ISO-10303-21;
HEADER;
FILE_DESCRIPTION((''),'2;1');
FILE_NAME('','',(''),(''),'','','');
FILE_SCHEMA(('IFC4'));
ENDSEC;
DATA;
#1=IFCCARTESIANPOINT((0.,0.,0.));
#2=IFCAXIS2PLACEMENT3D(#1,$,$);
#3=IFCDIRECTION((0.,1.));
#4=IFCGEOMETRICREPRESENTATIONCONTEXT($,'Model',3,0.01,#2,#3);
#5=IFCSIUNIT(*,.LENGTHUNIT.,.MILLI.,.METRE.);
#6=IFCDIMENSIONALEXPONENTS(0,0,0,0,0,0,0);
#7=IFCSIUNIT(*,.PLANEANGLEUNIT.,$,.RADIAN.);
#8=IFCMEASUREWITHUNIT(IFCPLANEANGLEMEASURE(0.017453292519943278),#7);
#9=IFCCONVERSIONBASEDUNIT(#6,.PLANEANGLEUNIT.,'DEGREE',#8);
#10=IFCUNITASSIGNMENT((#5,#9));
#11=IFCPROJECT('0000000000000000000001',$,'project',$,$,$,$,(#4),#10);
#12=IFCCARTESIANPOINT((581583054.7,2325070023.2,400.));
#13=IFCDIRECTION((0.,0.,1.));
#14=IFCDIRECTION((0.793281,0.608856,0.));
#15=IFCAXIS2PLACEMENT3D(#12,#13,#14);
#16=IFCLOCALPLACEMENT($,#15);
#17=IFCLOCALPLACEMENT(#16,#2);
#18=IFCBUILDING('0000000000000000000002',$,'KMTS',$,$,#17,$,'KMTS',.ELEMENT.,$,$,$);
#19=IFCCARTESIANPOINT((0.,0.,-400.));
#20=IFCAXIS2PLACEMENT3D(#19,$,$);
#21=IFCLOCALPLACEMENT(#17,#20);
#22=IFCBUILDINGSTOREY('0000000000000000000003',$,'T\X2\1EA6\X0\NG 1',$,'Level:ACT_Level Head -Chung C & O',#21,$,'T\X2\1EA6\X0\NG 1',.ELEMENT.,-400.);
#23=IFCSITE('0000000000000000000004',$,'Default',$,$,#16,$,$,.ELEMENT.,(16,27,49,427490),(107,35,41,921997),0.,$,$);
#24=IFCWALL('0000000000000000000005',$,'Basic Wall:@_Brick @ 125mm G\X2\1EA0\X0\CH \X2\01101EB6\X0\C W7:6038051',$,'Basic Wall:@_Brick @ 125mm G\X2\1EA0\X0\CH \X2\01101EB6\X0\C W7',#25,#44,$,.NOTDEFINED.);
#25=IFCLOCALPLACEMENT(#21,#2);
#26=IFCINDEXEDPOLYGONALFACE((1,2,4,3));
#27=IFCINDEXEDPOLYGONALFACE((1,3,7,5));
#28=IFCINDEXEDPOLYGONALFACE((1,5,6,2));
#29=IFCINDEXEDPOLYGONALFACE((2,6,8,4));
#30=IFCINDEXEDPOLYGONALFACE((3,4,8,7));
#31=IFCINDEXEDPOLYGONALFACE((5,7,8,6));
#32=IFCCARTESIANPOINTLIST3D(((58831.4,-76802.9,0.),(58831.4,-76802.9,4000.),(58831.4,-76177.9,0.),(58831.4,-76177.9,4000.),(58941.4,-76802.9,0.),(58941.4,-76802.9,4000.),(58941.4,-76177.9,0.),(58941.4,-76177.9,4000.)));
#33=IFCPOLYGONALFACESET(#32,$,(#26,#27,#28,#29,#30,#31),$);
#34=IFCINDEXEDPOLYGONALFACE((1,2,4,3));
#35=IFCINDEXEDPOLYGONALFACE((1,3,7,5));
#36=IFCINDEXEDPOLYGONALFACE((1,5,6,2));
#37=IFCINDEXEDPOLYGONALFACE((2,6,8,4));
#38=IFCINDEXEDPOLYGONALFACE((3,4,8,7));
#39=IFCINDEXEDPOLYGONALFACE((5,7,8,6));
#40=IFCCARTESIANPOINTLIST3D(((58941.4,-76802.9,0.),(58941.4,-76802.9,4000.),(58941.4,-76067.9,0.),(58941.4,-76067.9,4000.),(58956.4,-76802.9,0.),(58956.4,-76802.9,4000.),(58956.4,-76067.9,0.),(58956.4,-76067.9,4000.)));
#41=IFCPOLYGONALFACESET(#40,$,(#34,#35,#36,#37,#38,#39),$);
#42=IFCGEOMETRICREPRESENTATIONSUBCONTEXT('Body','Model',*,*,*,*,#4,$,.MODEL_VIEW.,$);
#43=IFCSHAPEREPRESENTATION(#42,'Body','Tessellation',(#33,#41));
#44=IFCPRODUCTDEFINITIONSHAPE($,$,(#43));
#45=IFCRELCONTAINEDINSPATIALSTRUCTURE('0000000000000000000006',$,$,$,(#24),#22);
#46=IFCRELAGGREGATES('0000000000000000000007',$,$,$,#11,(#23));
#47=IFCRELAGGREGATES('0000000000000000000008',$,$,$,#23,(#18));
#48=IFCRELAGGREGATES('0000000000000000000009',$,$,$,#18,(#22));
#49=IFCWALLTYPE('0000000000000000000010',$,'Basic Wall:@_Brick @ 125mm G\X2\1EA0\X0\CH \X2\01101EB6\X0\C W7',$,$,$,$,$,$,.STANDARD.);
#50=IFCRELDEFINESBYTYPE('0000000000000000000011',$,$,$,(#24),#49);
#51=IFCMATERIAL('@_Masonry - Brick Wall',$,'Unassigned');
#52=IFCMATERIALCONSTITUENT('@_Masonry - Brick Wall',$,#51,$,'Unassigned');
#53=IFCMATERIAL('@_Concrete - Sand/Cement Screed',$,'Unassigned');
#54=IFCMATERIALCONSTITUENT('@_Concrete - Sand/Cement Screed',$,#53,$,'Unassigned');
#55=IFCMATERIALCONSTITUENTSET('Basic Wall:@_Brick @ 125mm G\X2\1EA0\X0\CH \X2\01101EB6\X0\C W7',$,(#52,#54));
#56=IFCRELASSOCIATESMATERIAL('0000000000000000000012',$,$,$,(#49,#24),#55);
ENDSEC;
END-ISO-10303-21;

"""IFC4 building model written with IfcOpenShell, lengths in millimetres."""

from ifc_helpers import new_model, entity, si_unit, converted_unit, direction, frame, origin, place, context, subcontext, project, spatial, indexed_curve, outline, extrude, material, constituent, constituent_set, type_object, element, save


model = new_model("IFC4")

# Units and contexts
model_context = context("Model", 3, precision=0.01, world=origin(), true_north=direction((0.0, 1.0)))
body_context = subcontext(model_context, "Body", "Model", "MODEL_VIEW")
ifc_project = project(units=[si_unit("LENGTHUNIT", "METRE", prefix="MILLI"), converted_unit("PLANEANGLEUNIT", "DEGREE", entity("IfcPlaneAngleMeasure", 0.017453292519943278), si_unit("PLANEANGLEUNIT", "RADIAN"), dimensions=[0, 0, 0, 0, 0, 0, 0])], contexts=[model_context])

# Site, building, storey
site_placement = place(None, frame((581583054.7, 2325070023.2, 400.0), z_axis=(0.0, 0.0, 1.0), x_axis=(0.793281, 0.608856, 0.0)))
site = spatial("IfcSite", under=ifc_project, at=site_placement, Name="Default", CompositionType="ELEMENT", RefLatitude=(16, 27, 49, 427490), RefLongitude=(107, 35, 41, 921997), RefElevation=0.0)
building_placement = place(site_placement, origin())
building = spatial("IfcBuilding", under=site, at=building_placement, Name="KMTS", LongName="KMTS", CompositionType="ELEMENT")
storey_placement = place(building_placement, frame((0.0, 0.0, -400.0)))
storey = spatial("IfcBuildingStorey", under=building, at=storey_placement, Name="TẦNG 1", ObjectType="Level:ACT_Level Head -Chung C & O", LongName="TẦNG 1", CompositionType="ELEMENT", Elevation=-400.0)

# Wall
ifc_material_1 = material(Name="@_Masonry - Brick Wall", Category="Unassigned")
ifc_constituent_1 = constituent(ifc_material_1, Name="@_Masonry - Brick Wall", Category="Unassigned")
ifc_material_2 = material(Name="@_Concrete - Sand/Cement Screed", Category="Unassigned")
ifc_constituent_2 = constituent(ifc_material_2, Name="@_Concrete - Sand/Cement Screed", Category="Unassigned")
ifc_constituent_set_1 = constituent_set(constituents=[ifc_constituent_1, ifc_constituent_2], Name="Basic Wall:@_Brick @ 125mm GẠCH ĐẶC W7")
wall_type_1 = type_object("IfcWallType", Name="Basic Wall:@_Brick @ 125mm GẠCH ĐẶC W7", PredefinedType="STANDARD", material=ifc_constituent_set_1)
wall_1_placement = place(storey_placement, frame((58893.9, -76177.9, 0.0), z_axis=(0.0, 0.0, 1.0), x_axis=(0.0, -1.0, 0.0)))
element("IfcWall", 1, at=wall_1_placement, inside=storey, type_object=wall_type_1, material=ifc_constituent_set_1, Name="Basic Wall:@_Brick @ 125mm GẠCH ĐẶC W7:6038051", ObjectType="Basic Wall:@_Brick @ 125mm GẠCH ĐẶC W7", PredefinedType="NOTDEFINED", context=body_context, shape_type="SweptSolid", body=[
    extrude(outline(indexed_curve([(-55.0, -312.5), (55.0, -312.5), (55.0, 312.5), (-55.0, 312.5), (-55.0, -312.5)], self_intersect=False)), frame((312.5, -7.5, 0.0), z_axis=(0.0, 0.0, 1.0), x_axis=(0.0, 1.0, 0.0)), (0.0, 0.0, 1.0), 4000.0),
    extrude(outline(indexed_curve([(-7.5, -367.5), (7.5, -367.5), (7.5, 367.5), (-7.5, 367.5), (-7.5, -367.5)], self_intersect=False)), frame((257.5, 55.0, 0.0), z_axis=(0.0, 0.0, 1.0), x_axis=(0.0, -1.0, 0.0)), (0.0, 0.0, 1.0), 4000.0),
])

save(model, "model.ifc")
